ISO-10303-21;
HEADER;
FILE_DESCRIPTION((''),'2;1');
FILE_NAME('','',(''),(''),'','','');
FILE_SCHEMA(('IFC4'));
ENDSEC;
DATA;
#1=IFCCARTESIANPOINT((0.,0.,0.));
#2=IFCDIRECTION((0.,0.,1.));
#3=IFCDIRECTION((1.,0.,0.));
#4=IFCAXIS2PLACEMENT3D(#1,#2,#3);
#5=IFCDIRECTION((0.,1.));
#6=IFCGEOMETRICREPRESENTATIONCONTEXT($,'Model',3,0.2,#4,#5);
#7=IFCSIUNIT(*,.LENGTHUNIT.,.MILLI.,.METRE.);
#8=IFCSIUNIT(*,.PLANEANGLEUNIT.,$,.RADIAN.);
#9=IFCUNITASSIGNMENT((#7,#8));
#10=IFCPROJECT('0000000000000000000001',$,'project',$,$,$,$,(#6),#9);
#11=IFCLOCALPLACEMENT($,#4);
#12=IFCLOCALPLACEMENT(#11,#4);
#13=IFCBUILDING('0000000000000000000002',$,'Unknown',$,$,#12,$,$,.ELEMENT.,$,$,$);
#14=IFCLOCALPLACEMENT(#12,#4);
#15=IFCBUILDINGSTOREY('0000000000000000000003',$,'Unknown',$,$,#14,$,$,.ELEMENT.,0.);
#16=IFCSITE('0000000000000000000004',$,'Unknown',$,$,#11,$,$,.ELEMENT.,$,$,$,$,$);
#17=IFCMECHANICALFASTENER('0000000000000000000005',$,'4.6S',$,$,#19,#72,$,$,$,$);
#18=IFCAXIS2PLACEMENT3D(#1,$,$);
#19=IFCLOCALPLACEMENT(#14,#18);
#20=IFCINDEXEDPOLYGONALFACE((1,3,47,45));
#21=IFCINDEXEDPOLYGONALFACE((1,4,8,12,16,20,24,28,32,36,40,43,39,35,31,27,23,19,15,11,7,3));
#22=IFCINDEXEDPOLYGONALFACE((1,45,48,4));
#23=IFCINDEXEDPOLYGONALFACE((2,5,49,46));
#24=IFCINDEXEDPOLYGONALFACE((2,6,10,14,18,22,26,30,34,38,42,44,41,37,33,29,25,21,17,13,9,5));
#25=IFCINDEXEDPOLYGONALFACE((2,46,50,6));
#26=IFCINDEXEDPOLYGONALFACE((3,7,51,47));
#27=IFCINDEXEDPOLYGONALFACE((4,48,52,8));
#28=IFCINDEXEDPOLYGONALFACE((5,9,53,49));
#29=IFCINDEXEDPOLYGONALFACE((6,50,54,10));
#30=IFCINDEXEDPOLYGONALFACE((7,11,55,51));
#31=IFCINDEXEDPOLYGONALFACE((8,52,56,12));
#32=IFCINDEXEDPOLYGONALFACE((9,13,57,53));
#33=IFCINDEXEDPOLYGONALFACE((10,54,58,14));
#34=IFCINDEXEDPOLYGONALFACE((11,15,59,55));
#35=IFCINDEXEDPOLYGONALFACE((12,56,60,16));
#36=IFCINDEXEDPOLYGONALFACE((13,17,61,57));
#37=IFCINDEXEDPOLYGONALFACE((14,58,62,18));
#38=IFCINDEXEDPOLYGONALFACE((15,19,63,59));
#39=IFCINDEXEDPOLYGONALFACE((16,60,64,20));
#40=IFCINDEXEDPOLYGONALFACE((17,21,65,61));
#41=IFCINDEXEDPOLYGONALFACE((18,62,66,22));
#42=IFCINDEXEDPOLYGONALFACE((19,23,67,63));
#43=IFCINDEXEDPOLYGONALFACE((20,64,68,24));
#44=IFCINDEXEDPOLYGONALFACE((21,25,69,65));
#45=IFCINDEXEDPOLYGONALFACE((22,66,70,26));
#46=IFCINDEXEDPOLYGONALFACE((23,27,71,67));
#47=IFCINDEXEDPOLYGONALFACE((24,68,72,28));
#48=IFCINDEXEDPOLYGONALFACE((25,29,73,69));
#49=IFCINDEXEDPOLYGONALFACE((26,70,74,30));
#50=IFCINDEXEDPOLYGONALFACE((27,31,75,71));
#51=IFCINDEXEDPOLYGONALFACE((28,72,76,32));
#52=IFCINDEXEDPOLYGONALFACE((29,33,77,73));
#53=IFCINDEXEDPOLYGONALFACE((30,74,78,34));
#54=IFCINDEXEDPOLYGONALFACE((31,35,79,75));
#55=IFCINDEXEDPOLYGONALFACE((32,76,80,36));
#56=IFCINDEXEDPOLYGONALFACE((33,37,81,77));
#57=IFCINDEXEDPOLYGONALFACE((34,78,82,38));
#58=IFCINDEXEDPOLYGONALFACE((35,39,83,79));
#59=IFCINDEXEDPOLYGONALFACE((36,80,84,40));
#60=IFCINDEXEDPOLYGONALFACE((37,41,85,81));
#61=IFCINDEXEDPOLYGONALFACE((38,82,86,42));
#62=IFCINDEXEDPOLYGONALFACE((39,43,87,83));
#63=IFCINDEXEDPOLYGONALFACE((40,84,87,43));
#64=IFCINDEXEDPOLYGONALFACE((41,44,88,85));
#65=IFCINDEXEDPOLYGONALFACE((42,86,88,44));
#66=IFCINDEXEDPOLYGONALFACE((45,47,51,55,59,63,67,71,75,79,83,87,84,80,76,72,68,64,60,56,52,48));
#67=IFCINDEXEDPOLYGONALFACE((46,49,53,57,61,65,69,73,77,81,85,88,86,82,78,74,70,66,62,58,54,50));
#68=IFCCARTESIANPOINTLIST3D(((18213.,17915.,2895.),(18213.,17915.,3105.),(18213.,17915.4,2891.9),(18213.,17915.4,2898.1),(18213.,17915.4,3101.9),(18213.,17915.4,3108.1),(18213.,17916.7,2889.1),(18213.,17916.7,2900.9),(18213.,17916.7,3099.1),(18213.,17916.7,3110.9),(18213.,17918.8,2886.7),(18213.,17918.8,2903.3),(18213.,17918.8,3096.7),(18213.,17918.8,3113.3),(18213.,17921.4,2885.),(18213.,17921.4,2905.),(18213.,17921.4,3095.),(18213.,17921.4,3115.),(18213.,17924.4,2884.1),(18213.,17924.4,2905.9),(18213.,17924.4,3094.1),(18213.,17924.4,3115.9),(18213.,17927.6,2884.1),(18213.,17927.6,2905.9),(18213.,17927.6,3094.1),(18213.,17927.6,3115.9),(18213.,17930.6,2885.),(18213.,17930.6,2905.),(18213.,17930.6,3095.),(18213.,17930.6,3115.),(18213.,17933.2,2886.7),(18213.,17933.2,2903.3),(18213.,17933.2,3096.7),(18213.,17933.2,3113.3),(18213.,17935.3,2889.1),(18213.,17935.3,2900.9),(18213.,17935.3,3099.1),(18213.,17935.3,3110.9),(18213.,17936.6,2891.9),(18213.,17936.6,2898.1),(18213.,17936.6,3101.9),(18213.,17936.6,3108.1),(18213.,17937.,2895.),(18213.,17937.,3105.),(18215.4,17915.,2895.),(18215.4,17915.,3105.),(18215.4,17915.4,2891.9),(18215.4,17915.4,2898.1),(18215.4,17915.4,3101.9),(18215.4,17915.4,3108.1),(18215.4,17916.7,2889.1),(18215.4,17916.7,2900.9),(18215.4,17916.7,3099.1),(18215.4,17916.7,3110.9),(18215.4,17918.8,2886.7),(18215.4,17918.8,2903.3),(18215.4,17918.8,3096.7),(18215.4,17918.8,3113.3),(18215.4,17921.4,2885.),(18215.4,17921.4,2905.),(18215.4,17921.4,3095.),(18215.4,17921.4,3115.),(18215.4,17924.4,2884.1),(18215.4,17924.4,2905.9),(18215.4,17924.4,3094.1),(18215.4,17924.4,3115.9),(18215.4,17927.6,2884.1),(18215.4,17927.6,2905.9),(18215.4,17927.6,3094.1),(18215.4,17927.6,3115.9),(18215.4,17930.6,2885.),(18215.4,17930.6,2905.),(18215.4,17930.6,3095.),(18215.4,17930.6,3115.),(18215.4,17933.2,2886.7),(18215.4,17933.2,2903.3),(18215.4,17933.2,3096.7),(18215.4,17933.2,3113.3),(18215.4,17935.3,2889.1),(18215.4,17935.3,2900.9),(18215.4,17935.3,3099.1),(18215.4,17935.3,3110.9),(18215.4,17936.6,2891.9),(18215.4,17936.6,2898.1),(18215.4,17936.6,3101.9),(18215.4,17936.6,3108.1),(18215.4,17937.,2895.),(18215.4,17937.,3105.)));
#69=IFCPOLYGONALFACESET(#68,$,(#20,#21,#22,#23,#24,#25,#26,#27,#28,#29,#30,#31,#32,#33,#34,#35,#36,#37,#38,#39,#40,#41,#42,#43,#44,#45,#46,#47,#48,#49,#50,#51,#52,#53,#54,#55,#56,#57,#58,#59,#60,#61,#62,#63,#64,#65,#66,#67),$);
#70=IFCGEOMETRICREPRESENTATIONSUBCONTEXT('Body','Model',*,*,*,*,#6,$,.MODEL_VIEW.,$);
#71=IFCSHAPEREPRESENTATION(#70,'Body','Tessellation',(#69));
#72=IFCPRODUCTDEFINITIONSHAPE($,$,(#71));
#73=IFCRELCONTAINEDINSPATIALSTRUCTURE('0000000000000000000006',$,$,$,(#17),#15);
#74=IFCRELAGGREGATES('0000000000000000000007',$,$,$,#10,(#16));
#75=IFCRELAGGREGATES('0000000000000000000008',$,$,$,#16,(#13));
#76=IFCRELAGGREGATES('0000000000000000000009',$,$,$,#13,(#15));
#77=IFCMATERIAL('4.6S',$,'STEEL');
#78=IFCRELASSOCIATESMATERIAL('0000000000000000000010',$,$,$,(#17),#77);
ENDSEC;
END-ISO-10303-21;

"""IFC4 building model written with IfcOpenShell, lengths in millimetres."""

from ifc_helpers import new_model, si_unit, direction, frame, origin_with_axes, place, context, subcontext, project, spatial, arc, indexed_curve, outline, extrude, source, transform, mapped, material, element, save


model = new_model("IFC4")

# Units and contexts
model_context = context("Model", 3, precision=0.2, world=origin_with_axes(), true_north=direction((0.0, 1.0)))
body_context = subcontext(model_context, "Body", "Model", "MODEL_VIEW")
ifc_project = project(units=[si_unit("LENGTHUNIT", "METRE", prefix="MILLI"), si_unit("PLANEANGLEUNIT", "RADIAN")], contexts=[model_context])

# Site, building, storey
site_placement = place(None, origin_with_axes())
site = spatial("IfcSite", under=ifc_project, at=site_placement, Name="Unknown", CompositionType="ELEMENT")
building_placement = place(site_placement, origin_with_axes())
building = spatial("IfcBuilding", under=site, at=building_placement, Name="Unknown", CompositionType="ELEMENT")
storey_placement = place(building_placement, origin_with_axes())
storey = spatial("IfcBuildingStorey", under=building, at=storey_placement, Name="Unknown", CompositionType="ELEMENT", Elevation=0.0)

# Mechanical fastener
ifc_material_1 = material(Name="4.6S", Category="STEEL")
shared_shape_1 = source(origin_with_axes(), body_context, "Body", "SweptSolid", [
    extrude(outline(indexed_curve([(11.0, 0.0), (0.0, 11.0), (-11.0, 0.0), (0.0, -11.0)], segments=[arc(1, 2, 3), arc(3, 4, 1)])), frame((0.0, 0.0, 1.2), z_axis=(0.0, 0.0, -1.0), x_axis=(0.0, 1.0, 0.0)), (0.0, 0.0, 1.0), 2.4),
])
for number, where, z_axis, x_axis, name in (
    (1, (18214.2, 17926.0, 2895.0), (-1.0, 0.0, 0.0), (0.0, 0.0, 1.0), "4.6S"),
):
    element("IfcMechanicalFastener", number, at=place(storey_placement, frame(where, z_axis=z_axis, x_axis=x_axis)), inside=storey, material=ifc_material_1, Name=name, context=body_context, shape_type="MappedRepresentation", body=[
        mapped(shared_shape_1, transform((0.0, 0.0, 0.0))),
        mapped(shared_shape_1, transform((210.0, 0.0, 0.0))),
    ])

save(model, "model.ifc")
